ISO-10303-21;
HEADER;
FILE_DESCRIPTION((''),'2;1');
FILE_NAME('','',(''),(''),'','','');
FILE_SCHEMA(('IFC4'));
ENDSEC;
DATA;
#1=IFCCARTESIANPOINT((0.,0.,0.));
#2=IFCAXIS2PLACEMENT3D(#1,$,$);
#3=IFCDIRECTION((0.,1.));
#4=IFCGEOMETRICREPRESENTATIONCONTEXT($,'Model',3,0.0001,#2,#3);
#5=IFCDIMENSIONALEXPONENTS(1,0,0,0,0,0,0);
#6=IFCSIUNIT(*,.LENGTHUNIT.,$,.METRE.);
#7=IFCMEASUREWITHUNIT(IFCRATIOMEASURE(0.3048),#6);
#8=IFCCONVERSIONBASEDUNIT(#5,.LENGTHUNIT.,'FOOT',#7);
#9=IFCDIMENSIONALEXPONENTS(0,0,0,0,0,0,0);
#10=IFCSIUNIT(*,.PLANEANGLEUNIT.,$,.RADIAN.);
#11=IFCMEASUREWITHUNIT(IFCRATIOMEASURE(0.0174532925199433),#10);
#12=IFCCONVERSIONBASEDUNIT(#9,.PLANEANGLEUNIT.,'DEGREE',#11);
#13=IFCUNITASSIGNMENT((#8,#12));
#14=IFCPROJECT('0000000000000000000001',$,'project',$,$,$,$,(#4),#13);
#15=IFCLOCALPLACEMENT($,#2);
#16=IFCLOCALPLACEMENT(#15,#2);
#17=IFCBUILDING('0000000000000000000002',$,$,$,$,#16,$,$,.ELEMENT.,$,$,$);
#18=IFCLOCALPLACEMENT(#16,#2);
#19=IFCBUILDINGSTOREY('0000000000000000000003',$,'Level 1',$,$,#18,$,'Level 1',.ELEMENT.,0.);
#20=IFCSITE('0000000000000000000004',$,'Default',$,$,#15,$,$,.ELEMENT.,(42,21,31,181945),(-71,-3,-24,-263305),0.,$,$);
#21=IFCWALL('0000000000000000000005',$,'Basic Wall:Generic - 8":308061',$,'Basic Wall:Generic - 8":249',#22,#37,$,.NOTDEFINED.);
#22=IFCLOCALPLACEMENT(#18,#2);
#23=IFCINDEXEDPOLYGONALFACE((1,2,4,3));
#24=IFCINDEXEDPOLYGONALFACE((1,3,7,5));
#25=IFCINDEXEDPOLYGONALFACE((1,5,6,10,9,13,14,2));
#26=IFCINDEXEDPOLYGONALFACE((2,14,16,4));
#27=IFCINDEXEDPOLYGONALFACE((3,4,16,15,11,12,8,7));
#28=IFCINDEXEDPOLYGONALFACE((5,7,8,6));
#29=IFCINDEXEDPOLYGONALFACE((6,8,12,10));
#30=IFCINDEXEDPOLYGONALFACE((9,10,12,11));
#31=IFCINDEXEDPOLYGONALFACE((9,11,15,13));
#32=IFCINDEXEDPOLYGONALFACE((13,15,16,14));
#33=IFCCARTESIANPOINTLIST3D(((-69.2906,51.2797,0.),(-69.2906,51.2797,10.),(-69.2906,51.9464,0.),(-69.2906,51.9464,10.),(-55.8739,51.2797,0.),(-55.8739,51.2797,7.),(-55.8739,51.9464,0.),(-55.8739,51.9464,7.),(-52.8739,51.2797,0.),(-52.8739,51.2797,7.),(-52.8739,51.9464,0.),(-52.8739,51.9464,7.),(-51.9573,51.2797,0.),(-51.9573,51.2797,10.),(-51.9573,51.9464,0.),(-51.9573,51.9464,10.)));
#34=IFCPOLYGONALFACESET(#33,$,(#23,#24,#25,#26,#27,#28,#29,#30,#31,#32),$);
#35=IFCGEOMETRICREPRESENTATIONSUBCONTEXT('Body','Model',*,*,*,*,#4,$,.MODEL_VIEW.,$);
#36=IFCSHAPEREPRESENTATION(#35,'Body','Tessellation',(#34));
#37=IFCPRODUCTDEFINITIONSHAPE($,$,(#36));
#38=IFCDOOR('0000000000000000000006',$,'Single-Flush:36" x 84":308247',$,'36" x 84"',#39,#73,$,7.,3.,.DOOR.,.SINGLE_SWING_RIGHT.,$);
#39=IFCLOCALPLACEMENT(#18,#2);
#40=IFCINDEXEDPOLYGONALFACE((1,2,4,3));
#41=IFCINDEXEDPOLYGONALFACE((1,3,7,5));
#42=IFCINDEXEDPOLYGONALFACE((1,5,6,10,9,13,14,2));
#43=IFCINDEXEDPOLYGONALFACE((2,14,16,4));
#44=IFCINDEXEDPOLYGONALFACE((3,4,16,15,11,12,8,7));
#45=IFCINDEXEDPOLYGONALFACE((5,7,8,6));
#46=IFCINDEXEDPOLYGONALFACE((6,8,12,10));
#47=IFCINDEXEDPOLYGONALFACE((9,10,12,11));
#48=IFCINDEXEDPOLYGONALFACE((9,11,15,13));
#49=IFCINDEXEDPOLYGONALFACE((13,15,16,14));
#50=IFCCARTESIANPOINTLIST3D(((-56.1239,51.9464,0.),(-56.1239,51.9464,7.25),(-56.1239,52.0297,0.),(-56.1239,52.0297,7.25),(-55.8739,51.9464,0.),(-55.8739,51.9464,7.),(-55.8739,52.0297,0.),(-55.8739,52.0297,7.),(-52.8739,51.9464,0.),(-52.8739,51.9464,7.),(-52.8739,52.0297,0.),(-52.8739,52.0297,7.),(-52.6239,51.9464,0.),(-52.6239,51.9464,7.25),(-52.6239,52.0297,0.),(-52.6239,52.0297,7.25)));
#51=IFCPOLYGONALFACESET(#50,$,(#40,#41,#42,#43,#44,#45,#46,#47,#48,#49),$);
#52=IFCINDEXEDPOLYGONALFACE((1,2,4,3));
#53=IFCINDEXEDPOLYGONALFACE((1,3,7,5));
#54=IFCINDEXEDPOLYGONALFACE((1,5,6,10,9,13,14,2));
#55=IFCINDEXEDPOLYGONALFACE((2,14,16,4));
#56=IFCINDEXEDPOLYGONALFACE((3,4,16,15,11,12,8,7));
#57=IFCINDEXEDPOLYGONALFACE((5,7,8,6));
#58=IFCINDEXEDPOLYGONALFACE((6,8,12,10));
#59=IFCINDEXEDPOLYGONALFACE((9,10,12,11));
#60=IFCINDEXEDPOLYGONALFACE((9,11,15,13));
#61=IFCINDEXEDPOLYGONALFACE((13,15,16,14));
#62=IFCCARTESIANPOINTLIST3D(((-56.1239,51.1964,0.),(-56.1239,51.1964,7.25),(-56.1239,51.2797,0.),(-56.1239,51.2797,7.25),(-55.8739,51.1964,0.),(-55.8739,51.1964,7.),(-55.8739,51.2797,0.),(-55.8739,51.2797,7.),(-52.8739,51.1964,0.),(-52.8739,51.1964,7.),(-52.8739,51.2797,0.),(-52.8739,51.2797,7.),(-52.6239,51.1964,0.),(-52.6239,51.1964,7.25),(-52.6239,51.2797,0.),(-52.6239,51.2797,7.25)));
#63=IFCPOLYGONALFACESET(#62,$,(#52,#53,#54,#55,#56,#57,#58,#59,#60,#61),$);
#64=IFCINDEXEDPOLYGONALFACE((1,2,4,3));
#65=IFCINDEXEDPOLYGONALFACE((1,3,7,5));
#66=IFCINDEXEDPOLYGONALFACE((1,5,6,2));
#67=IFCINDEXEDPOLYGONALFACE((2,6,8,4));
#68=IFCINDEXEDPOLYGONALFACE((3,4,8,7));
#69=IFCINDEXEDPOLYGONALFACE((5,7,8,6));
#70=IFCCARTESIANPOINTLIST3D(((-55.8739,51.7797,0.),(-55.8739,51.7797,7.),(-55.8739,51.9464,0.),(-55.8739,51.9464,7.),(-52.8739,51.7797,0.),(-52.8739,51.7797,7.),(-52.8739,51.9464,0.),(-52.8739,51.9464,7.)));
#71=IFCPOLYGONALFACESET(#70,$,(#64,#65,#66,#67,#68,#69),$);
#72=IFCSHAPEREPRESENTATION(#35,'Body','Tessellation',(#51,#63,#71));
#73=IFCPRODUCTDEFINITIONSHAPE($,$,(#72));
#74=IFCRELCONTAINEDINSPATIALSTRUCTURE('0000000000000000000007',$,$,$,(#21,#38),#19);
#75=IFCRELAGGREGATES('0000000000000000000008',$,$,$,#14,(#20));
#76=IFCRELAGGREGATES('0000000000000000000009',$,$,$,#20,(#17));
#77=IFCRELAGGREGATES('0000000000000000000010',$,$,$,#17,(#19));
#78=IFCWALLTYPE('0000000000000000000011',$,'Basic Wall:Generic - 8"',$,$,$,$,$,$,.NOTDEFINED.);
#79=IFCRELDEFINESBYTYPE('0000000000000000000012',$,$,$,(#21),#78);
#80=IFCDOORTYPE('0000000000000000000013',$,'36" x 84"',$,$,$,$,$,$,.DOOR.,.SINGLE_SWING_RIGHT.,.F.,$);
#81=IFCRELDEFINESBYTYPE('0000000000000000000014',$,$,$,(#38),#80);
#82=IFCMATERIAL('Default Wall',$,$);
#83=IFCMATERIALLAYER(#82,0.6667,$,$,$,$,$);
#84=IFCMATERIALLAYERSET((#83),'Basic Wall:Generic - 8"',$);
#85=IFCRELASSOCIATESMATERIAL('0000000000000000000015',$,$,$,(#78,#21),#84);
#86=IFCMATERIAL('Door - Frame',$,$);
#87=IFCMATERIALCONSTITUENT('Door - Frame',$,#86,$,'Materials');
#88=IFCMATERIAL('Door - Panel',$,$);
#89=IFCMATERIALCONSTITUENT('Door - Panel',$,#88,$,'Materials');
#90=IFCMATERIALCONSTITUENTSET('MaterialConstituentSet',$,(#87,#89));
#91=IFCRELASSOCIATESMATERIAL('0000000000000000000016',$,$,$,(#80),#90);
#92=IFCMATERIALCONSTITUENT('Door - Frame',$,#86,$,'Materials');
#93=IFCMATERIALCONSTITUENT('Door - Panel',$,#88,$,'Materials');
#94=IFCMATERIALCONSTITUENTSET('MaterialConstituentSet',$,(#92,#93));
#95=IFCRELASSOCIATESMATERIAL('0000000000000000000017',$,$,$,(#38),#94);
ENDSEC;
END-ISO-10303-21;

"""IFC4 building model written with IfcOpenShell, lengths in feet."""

from ifc_helpers import new_model, entity, si_unit, converted_unit, direction, frame, frame_2d, origin, place, context, subcontext, project, spatial, polyline, rectangle, outline, extrude, source, transform, mapped, material, layer, layer_set, layer_usage, constituent, constituent_set, type_object, type_shapes, element, fill, save


model = new_model("IFC4")

# Units and contexts
model_context = context("Model", 3, precision=0.0001, world=origin(), true_north=direction((0.0, 1.0)))
body_context = subcontext(model_context, "Body", "Model", "MODEL_VIEW")
ifc_project = project(units=[converted_unit("LENGTHUNIT", "FOOT", entity("IfcRatioMeasure", 0.3048), si_unit("LENGTHUNIT", "METRE"), dimensions=[1, 0, 0, 0, 0, 0, 0]), converted_unit("PLANEANGLEUNIT", "DEGREE", entity("IfcRatioMeasure", 0.0174532925199433), si_unit("PLANEANGLEUNIT", "RADIAN"), dimensions=[0, 0, 0, 0, 0, 0, 0])], contexts=[model_context])

# Site, building, storey
site_placement = place(None, origin())
site = spatial("IfcSite", under=ifc_project, at=site_placement, Name="Default", CompositionType="ELEMENT", RefLatitude=(42, 21, 31, 181945), RefLongitude=(-71, -3, -24, -263305), RefElevation=0.0)
building_placement = place(site_placement, origin())
building = spatial("IfcBuilding", under=site, at=building_placement, CompositionType="ELEMENT")
storey_placement = place(building_placement, origin())
storey = spatial("IfcBuildingStorey", under=building, at=storey_placement, Name="Level 1", LongName="Level 1", CompositionType="ELEMENT", Elevation=0.0)

# Shared definitions
ifc_material_1 = material(Name="Default Wall")
ifc_layer = layer(ifc_material_1, 0.6667)
ifc_layer_set = layer_set([ifc_layer], Name="Basic Wall:Generic - 8\"")
wall_type = type_object("IfcWallType", Name="Basic Wall:Generic - 8\"", PredefinedType="NOTDEFINED", material=ifc_layer_set)

# Wall, opening, door
ifc_material_2 = material(Name="Door - Frame")
ifc_material_3 = material(Name="Door - Panel")
ifc_layer_usage_1 = layer_usage(ifc_layer_set, "AXIS2", "NEGATIVE", 0.3333)
wall_1_placement = place(storey_placement, frame((-69.2906, 51.6131, 0.0)))
wall_1 = element("IfcWall", 1, at=wall_1_placement, inside=storey, type_object=wall_type, material=ifc_layer_usage_1, Name="Basic Wall:Generic - 8\":308061", ObjectType="Basic Wall:Generic - 8\":249", PredefinedType="NOTDEFINED", context=body_context, shape_type="SweptSolid", body=[
    extrude(rectangle(XDim=17.3333, YDim=0.6667, at=frame_2d((8.6667, 0.0), x_axis=(-1.0, 0.0))), origin(), (0.0, 0.0, 1.0), 10.0),
])
opening_1_placement = place(wall_1_placement, frame((13.4167, -0.3333, 0.0)))
opening_1 = element("IfcOpeningElement", 2, at=opening_1_placement, cuts=wall_1, ObjectType="Opening", PredefinedType="OPENING", context=body_context, shape_type="SweptSolid", body=[
    extrude(rectangle(XDim=3.0, YDim=7.0, at=frame_2d((3.5, 1.5), x_axis=(0.0, 1.0))), frame((0.0, 0.0, 0.0), z_axis=(0.0, 1.0, 0.0), x_axis=(0.0, 0.0, 1.0)), (0.0, 0.0, 1.0), 0.6667),
])
ifc_constituent_1 = constituent(ifc_material_2, Name="Door - Frame", Category="Materials")
ifc_constituent_2 = constituent(ifc_material_3, Name="Door - Panel", Category="Materials")
ifc_constituent_set_1 = constituent_set(constituents=[ifc_constituent_1, ifc_constituent_2], Name="MaterialConstituentSet")
ifc_constituent_3 = constituent(ifc_material_2, Name="Door - Frame", Category="Materials")
ifc_constituent_4 = constituent(ifc_material_3, Name="Door - Panel", Category="Materials")
ifc_constituent_set_2 = constituent_set(constituents=[ifc_constituent_3, ifc_constituent_4], Name="MaterialConstituentSet")
door_type_1 = type_object("IfcDoorType", Name="36\" x 84\"", OperationType="SINGLE_SWING_RIGHT", ParameterTakesPrecedence=False, PredefinedType="DOOR", material=ifc_constituent_set_2)
shared_shape_1 = source(origin(), body_context, "Body", "SweptSolid", [
    extrude(outline(polyline([(-1.75, -3.6875), (1.75, -3.6875), (1.75, 3.5625), (1.5, 3.5625), (1.5, -3.4375), (-1.5, -3.4375), (-1.5, 3.5625), (-1.75, 3.5625), (-1.75, -3.6875)])), frame((1.5, 0.6667, 3.5625), z_axis=(0.0, 1.0, 0.0), x_axis=(1.0, 0.0, 0.0)), (0.0, 0.0, 1.0), 0.0833),
    extrude(outline(polyline([(-3.6875, -1.75), (3.5625, -1.75), (3.5625, -1.5), (-3.4375, -1.5), (-3.4375, 1.5), (3.5625, 1.5), (3.5625, 1.75), (-3.6875, 1.75), (-3.6875, -1.75)])), frame((1.5, -0.0833, 3.5625), z_axis=(0.0, 1.0, 0.0), x_axis=(0.0, 0.0, -1.0)), (0.0, 0.0, 1.0), 0.0833),
    extrude(rectangle(XDim=0.1667, YDim=3.0, at=frame_2d((0.0, 0.0), x_axis=(1.0, 0.0))), frame((1.5, 0.5833, 0.0), z_axis=(0.0, 0.0, 1.0), x_axis=(0.0, 1.0, 0.0)), (0.0, 0.0, 1.0), 7.0),
])
type_shapes(door_type_1, [shared_shape_1])
door_1_placement = place(opening_1_placement, origin())
door_1 = element("IfcDoor", 3, at=door_1_placement, inside=storey, type_object=door_type_1, material=ifc_constituent_set_1, Name="Single-Flush:36\" x 84\":308247", ObjectType="36\" x 84\"", OperationType="SINGLE_SWING_RIGHT", OverallHeight=7.0, OverallWidth=3.0, PredefinedType="DOOR", context=body_context, shape_type="MappedRepresentation", body=[
    mapped(shared_shape_1, transform((0.0, 0.0, 0.0), scale=1.0)),
])
fill(opening_1, door_1)

save(model, "model.ifc")
